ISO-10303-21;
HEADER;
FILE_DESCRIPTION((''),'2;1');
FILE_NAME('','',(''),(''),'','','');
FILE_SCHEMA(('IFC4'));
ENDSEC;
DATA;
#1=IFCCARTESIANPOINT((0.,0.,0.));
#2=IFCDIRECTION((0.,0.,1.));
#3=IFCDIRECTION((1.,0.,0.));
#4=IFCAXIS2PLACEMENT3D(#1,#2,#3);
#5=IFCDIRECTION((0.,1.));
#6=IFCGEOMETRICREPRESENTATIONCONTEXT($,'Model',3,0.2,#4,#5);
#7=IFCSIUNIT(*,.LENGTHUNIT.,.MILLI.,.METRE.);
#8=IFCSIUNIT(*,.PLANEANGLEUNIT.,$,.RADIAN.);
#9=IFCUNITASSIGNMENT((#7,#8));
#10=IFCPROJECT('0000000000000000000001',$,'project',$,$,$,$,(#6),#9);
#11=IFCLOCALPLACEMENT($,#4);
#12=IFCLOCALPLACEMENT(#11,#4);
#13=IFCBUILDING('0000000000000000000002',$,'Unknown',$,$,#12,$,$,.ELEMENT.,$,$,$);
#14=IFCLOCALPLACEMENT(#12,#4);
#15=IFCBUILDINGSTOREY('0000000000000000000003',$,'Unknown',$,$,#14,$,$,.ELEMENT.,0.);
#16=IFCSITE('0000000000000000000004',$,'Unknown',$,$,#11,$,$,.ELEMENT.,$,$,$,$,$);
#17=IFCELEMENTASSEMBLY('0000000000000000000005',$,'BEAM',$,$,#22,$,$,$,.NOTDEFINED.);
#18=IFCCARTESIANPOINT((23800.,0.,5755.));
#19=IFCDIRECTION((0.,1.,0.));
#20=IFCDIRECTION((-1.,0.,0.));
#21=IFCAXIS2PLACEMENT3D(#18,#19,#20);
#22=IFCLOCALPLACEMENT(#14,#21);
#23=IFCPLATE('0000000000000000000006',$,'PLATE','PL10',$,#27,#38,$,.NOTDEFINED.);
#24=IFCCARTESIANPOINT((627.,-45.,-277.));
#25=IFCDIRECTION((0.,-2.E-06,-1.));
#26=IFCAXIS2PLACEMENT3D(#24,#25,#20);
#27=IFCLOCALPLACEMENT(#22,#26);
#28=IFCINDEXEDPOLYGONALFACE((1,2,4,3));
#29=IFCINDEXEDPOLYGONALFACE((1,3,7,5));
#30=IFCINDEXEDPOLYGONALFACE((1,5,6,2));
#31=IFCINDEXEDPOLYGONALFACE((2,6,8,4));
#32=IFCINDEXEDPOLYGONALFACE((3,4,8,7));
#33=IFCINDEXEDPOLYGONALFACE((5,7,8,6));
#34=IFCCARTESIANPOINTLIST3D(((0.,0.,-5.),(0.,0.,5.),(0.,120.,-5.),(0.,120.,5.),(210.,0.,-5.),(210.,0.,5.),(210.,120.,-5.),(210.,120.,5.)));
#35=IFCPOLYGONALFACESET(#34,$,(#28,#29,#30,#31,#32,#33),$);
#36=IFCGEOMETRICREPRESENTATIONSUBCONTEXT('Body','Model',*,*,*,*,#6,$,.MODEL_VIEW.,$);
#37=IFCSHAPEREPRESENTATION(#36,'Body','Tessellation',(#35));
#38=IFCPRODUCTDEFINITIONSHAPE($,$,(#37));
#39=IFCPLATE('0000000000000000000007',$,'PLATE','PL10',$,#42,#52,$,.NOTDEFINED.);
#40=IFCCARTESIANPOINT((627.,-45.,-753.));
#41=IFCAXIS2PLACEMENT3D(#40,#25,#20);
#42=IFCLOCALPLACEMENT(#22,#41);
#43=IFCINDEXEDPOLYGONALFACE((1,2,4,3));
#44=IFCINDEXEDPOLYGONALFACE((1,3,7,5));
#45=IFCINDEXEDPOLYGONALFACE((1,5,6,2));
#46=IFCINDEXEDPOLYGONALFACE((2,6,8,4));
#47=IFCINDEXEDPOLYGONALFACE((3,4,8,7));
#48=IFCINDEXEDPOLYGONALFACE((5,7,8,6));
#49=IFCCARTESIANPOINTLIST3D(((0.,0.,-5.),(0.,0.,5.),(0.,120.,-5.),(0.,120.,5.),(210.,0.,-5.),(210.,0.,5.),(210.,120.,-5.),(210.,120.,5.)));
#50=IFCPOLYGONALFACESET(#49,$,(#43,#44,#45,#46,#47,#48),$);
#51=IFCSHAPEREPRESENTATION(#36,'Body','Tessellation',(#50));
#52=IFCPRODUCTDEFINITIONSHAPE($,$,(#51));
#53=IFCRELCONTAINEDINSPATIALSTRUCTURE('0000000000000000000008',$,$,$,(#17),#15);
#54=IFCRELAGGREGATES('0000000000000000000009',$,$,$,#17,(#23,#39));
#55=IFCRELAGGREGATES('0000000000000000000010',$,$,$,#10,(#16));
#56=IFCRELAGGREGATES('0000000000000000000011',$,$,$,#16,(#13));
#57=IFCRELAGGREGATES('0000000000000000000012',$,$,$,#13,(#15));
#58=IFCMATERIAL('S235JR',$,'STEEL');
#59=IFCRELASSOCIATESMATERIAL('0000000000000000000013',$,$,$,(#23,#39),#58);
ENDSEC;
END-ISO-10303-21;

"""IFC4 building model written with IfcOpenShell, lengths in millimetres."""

from ifc_helpers import new_model, si_unit, direction, frame, origin_with_axes, place, context, subcontext, project, spatial, line, indexed_curve, outline, extrude, material, element, aggregate, save


model = new_model("IFC4")

# Units and contexts
model_context = context("Model", 3, precision=0.2, world=origin_with_axes(), true_north=direction((0.0, 1.0)))
body_context = subcontext(model_context, "Body", "Model", "MODEL_VIEW")
ifc_project = project(units=[si_unit("LENGTHUNIT", "METRE", prefix="MILLI"), si_unit("PLANEANGLEUNIT", "RADIAN")], contexts=[model_context])

# Site, building, storey
site_placement = place(None, origin_with_axes())
site = spatial("IfcSite", under=ifc_project, at=site_placement, Name="Unknown", CompositionType="ELEMENT")
building_placement = place(site_placement, origin_with_axes())
building = spatial("IfcBuilding", under=site, at=building_placement, Name="Unknown", CompositionType="ELEMENT")
storey_placement = place(building_placement, origin_with_axes())
storey = spatial("IfcBuildingStorey", under=building, at=storey_placement, Name="Unknown", CompositionType="ELEMENT", Elevation=0.0)

# Element assembly
assembly_1_placement = place(storey_placement, frame((23800.0, 0.0, 5755.0), z_axis=(0.0, 1.0, 0.0), x_axis=(-1.0, 0.0, 0.0)))
assembly_1 = element("IfcElementAssembly", 1, at=assembly_1_placement, inside=storey, Name="BEAM", PredefinedType="NOTDEFINED")

# Plates
ifc_material_1 = material(Name="S235JR", Category="STEEL")
plate_1_placement = place(assembly_1_placement, frame((627.0, -45.0, -277.0), z_axis=(0.0, -0.000002, -1.0), x_axis=(-1.0, 0.0, 0.0)))
plate_1 = element("IfcPlate", 2, at=plate_1_placement, material=ifc_material_1, Name="PLATE", Description="PL10", PredefinedType="NOTDEFINED", context=body_context, shape_type="SolidModel", body=[
    extrude(outline(indexed_curve([(0.0, 0.0), (210.0, 0.0), (210.0, 120.0), (0.0, 120.0)], segments=[line(1, 2, 3, 4, 1)])), frame((0.0, 0.0, 5.0), z_axis=(0.0, 0.0, 1.0), x_axis=(1.0, 0.0, 0.0)), (0.0, -0.000002, -1.0), 10.0),
])
plate_2_placement = place(assembly_1_placement, frame((627.0, -45.0, -753.0), z_axis=(0.0, -0.000002, -1.0), x_axis=(-1.0, 0.0, 0.0)))
plate_2 = element("IfcPlate", 3, at=plate_2_placement, material=ifc_material_1, Name="PLATE", Description="PL10", PredefinedType="NOTDEFINED", context=body_context, shape_type="SolidModel", body=[
    extrude(outline(indexed_curve([(0.0, 0.0), (210.0, 0.0), (210.0, 120.0), (0.0, 120.0)], segments=[line(1, 2, 3, 4, 1)])), frame((0.0, 0.0, 5.0), z_axis=(0.0, 0.0, 1.0), x_axis=(1.0, 0.0, 0.0)), (0.0, -0.000002, -1.0), 10.0),
])

aggregate(assembly_1, [plate_1, plate_2])

save(model, "model.ifc")
